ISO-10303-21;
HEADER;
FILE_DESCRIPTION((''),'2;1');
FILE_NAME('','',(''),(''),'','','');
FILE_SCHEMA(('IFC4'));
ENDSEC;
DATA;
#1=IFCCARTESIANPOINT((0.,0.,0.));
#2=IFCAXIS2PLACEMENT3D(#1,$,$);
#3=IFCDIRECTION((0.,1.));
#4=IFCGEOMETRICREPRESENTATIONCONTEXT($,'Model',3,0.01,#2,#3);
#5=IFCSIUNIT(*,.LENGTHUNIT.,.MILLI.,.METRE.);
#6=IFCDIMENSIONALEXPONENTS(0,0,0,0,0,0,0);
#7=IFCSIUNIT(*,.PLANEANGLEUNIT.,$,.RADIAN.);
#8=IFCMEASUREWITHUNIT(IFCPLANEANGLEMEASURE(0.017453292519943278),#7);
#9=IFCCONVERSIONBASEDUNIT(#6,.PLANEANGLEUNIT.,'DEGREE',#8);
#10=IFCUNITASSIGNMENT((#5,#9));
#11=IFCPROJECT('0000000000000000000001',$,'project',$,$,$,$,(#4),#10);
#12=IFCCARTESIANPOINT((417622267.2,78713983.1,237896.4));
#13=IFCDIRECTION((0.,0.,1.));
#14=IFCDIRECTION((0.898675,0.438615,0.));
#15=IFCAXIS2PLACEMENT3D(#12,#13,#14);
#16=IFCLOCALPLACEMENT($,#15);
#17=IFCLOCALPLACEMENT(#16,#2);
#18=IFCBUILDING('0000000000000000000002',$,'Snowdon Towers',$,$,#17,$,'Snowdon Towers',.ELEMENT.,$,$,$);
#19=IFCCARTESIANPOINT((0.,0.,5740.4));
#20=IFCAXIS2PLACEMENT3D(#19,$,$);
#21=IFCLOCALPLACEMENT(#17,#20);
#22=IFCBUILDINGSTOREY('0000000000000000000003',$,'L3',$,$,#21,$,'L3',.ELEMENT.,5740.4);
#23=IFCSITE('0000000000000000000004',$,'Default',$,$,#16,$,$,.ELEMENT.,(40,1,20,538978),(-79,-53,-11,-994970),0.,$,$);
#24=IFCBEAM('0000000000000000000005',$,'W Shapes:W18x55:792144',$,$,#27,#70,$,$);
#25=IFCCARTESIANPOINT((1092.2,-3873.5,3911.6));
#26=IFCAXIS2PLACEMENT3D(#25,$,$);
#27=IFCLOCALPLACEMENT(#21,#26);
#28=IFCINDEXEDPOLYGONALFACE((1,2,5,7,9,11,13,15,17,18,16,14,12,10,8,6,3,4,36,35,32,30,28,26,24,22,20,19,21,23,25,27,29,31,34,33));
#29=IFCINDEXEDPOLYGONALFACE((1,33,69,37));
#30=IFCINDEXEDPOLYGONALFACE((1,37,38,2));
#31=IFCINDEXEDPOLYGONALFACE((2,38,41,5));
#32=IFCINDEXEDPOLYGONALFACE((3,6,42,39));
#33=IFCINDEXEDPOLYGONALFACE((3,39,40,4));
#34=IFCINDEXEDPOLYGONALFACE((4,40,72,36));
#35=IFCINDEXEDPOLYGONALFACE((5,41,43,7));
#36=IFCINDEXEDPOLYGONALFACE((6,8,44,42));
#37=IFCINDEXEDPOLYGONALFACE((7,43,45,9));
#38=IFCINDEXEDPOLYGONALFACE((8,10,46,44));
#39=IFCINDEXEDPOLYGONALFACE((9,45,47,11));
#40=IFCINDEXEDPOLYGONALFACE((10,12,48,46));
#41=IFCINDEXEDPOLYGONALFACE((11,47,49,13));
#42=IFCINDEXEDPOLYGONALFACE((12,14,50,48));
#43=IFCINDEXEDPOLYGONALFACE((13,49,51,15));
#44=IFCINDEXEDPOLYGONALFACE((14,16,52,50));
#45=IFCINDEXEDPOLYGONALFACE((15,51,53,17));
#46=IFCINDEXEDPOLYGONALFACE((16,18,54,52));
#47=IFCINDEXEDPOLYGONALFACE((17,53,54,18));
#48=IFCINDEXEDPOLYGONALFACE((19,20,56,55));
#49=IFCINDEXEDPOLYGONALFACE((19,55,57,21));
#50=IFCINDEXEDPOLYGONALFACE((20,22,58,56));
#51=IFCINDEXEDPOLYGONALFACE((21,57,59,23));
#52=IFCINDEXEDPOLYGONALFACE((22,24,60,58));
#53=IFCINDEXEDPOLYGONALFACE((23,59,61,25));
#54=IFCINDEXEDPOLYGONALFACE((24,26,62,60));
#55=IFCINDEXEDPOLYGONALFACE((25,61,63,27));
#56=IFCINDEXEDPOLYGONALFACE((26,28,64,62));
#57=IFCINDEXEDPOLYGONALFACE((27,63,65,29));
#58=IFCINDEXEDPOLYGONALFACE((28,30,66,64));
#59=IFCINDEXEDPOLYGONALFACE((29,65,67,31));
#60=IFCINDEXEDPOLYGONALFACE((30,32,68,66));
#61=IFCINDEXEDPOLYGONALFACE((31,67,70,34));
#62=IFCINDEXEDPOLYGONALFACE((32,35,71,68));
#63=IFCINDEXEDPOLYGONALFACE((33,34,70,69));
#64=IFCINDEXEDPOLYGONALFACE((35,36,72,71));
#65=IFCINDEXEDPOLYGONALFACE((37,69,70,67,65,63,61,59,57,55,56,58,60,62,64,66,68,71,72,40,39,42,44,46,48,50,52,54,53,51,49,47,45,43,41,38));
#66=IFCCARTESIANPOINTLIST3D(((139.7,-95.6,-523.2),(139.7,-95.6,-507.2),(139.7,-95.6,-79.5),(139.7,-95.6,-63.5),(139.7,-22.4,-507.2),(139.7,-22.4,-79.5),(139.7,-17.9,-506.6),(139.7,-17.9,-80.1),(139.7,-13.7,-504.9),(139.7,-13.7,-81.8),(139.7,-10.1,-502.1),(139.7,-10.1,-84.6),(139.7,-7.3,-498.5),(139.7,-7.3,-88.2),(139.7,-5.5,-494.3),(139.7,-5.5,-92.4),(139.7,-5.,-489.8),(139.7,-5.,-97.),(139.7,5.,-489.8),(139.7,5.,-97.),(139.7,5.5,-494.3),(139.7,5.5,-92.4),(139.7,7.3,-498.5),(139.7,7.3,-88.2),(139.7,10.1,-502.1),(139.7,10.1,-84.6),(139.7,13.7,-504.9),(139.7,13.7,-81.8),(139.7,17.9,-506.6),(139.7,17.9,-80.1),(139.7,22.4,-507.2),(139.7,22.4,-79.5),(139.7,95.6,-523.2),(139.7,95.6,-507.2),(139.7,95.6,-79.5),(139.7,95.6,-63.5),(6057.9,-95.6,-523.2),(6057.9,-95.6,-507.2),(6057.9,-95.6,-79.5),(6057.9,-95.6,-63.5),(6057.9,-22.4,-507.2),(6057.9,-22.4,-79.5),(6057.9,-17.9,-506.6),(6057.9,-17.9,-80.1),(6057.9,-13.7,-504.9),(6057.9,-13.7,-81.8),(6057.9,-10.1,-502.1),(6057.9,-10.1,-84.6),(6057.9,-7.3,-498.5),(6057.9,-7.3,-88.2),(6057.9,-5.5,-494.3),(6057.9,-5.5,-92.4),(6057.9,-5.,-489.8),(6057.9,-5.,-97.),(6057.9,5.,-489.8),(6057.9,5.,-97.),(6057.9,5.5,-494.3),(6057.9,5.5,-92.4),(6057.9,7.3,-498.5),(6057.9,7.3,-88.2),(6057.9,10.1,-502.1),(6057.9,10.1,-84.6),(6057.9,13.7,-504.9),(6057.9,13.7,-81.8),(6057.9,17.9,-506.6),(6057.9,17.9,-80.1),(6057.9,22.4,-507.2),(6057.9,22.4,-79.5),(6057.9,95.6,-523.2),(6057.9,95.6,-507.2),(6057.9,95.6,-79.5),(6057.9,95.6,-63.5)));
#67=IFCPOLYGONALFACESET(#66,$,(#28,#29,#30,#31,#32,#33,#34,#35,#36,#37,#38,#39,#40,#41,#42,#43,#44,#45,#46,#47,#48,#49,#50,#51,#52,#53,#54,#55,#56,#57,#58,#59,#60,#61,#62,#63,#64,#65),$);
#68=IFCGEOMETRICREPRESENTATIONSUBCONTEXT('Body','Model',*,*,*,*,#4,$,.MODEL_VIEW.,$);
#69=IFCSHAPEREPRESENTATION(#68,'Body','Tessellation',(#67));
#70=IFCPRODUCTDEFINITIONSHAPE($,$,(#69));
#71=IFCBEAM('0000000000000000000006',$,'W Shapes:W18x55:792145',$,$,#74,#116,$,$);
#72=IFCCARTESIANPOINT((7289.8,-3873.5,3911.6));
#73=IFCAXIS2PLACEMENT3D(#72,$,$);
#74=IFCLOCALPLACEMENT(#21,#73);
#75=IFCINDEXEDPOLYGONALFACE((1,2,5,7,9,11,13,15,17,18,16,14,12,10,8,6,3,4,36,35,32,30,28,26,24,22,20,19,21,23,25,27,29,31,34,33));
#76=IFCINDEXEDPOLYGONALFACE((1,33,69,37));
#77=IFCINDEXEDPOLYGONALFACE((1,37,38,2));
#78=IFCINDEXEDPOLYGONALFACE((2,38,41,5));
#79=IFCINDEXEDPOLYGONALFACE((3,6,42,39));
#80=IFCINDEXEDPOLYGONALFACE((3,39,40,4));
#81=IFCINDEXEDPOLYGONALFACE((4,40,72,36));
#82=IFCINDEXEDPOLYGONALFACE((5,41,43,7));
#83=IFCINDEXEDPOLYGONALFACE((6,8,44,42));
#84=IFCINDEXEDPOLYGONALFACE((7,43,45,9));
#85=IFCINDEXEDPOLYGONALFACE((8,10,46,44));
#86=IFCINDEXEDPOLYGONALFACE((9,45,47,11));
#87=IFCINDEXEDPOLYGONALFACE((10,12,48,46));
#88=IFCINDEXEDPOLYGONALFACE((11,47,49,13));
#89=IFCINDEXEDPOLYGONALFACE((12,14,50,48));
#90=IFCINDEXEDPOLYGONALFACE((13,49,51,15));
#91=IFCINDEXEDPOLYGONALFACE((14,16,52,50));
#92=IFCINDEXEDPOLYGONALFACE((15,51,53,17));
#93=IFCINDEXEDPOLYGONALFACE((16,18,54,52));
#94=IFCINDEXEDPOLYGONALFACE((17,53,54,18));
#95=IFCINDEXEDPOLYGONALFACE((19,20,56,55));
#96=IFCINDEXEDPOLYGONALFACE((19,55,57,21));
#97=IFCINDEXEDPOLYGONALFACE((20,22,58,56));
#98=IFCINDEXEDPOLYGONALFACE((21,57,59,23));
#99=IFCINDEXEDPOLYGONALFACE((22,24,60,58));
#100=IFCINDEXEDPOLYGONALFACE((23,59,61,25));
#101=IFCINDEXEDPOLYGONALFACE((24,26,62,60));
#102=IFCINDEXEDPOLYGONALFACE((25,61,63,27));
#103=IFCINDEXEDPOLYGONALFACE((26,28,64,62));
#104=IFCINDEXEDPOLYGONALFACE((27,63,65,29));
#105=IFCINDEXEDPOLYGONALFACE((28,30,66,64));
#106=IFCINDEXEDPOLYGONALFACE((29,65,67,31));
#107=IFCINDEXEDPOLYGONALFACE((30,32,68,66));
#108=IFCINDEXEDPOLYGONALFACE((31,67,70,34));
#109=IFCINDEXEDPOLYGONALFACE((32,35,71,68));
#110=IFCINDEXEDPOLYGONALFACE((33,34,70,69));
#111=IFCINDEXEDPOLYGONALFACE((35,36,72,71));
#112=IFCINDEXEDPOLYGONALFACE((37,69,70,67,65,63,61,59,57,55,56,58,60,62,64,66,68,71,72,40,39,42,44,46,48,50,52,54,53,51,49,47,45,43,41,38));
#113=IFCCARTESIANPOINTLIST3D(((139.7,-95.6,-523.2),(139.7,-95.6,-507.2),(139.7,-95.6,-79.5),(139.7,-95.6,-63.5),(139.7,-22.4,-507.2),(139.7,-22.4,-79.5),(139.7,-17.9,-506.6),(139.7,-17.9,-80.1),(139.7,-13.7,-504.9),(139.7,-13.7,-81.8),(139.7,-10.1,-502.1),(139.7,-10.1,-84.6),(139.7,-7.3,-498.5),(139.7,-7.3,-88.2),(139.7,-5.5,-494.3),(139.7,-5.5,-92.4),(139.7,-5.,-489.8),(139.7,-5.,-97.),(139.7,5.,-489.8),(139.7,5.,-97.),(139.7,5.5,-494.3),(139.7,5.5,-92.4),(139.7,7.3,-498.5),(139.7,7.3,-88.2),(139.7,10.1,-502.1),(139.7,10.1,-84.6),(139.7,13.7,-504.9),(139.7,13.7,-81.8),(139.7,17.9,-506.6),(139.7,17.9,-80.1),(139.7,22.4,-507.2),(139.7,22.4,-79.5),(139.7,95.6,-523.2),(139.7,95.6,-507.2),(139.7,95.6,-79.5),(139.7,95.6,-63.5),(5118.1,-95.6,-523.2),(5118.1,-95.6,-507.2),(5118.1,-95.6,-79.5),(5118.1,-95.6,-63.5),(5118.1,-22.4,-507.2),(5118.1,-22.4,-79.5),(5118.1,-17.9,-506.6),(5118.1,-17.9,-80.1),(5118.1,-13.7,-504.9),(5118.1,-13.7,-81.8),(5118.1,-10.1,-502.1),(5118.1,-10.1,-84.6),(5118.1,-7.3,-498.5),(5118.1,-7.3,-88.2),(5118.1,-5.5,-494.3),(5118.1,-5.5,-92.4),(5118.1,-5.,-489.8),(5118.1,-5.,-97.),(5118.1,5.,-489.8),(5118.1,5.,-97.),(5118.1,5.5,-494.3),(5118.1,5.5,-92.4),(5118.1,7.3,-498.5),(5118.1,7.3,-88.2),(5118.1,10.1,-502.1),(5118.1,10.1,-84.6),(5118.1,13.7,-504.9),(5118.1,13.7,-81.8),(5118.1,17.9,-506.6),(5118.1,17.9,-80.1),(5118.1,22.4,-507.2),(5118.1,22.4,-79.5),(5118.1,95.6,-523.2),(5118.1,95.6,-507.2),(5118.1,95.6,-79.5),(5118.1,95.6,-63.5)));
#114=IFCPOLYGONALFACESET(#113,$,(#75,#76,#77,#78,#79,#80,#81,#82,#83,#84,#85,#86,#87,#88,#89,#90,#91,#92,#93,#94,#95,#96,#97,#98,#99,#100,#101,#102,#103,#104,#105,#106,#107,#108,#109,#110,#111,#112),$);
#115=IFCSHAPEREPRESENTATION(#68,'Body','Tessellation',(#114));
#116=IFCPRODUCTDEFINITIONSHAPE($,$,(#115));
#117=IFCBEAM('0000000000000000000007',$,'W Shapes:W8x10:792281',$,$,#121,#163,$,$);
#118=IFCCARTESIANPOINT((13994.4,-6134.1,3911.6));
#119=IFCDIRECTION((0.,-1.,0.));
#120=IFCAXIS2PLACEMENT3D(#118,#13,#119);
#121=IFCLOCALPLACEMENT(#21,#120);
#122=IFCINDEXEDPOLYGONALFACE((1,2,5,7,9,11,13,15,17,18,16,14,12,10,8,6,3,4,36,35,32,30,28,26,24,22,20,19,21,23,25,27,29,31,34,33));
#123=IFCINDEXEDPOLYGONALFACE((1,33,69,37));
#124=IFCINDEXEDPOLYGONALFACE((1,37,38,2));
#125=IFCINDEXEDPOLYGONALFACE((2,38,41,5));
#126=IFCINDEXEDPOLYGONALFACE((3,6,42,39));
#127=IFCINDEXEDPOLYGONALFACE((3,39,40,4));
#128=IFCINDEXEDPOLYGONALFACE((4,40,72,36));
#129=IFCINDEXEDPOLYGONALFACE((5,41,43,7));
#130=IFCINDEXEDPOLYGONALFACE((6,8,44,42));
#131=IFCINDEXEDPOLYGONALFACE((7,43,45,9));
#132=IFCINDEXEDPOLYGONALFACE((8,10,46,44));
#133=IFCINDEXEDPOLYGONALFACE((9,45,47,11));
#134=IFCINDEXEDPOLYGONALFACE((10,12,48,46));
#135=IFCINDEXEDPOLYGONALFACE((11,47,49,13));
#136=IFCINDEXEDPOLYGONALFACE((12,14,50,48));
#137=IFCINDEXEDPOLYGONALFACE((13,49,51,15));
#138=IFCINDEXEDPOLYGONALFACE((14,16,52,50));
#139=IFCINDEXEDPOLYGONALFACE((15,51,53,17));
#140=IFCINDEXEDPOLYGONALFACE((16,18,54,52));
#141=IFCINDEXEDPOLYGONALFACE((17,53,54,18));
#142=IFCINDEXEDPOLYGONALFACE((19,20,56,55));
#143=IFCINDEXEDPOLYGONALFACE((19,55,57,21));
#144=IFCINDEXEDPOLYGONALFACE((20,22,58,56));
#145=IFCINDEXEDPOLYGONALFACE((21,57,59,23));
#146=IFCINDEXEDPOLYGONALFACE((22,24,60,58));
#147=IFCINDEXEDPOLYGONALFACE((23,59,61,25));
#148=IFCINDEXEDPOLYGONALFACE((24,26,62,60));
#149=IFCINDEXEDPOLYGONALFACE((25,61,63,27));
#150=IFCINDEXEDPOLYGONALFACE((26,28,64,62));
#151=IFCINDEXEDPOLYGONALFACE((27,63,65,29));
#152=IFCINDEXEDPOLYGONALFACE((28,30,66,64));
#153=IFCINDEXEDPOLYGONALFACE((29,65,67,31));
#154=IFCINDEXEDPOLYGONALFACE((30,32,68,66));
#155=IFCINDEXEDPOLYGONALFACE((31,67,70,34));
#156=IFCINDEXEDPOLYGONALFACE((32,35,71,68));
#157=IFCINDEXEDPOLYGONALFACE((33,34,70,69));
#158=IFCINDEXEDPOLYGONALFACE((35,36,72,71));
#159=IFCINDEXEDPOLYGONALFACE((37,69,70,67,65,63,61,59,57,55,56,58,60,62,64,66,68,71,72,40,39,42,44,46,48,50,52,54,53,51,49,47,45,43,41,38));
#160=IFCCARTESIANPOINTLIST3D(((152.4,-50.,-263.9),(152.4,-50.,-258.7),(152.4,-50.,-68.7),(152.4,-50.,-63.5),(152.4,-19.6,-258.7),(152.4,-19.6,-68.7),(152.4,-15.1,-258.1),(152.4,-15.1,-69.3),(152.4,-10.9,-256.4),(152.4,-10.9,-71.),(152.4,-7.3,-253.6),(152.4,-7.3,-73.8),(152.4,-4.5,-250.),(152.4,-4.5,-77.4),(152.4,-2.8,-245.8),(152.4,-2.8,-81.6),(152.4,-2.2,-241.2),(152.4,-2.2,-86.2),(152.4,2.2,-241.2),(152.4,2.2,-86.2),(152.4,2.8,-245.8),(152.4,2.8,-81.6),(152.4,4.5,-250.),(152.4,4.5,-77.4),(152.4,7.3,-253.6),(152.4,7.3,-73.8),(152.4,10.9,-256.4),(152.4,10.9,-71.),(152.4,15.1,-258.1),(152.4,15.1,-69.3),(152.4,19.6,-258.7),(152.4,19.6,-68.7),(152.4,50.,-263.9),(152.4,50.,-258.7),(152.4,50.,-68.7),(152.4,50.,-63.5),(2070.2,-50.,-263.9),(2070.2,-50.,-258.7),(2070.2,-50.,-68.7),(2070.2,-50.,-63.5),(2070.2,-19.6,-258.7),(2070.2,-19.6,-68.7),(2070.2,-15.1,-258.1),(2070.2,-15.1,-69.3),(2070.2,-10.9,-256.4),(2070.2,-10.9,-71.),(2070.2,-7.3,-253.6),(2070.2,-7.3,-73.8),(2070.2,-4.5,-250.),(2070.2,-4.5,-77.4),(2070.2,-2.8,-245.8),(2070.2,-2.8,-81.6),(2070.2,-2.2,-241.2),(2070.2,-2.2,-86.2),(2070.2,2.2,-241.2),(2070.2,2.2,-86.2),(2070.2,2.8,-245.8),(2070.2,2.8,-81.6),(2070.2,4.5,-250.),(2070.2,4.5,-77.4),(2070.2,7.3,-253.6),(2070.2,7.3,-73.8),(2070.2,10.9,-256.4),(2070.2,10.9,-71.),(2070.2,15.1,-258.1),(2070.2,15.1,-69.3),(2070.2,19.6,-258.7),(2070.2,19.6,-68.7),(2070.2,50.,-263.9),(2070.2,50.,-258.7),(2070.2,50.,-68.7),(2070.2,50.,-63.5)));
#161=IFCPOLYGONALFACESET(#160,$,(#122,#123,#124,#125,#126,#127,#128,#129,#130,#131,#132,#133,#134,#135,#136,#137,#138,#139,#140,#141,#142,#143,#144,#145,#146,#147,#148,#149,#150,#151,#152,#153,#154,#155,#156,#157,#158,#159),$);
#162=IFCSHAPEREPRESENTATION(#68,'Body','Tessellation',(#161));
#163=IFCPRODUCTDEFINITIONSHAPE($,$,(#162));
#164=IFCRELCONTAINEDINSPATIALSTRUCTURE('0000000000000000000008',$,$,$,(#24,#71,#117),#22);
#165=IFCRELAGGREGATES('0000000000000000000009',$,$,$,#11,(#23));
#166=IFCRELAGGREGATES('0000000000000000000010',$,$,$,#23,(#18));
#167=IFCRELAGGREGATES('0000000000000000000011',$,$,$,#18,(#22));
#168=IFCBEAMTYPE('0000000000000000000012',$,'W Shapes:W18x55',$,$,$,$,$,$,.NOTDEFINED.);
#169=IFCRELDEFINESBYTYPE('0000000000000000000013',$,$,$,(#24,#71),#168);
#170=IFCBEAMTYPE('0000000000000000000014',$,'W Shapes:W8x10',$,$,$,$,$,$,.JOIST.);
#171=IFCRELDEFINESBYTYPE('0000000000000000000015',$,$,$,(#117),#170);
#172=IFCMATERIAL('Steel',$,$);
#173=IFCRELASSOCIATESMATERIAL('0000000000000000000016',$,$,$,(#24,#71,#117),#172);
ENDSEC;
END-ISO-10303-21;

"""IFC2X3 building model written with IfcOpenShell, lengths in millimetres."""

from ifc_helpers import new_model, entity, si_unit, converted_unit, direction, frame, frame_2d, origin, place, context, subcontext, project, spatial, i_section, extrude, material, type_object, element, save


model = new_model("IFC2X3")

# Units and contexts
model_context = context("Model", 3, precision=0.01, world=origin(), true_north=direction((0.0, 1.0)))
body_context = subcontext(model_context, "Body", "Model", "MODEL_VIEW")
ifc_project = project(units=[si_unit("LENGTHUNIT", "METRE", prefix="MILLI"), converted_unit("PLANEANGLEUNIT", "DEGREE", entity("IfcPlaneAngleMeasure", 0.017453292519943278), si_unit("PLANEANGLEUNIT", "RADIAN"), dimensions=[0, 0, 0, 0, 0, 0, 0])], contexts=[model_context])

# Site, building, storey
site_placement = place(None, frame((417622267.2, 78713983.1, 237896.4), z_axis=(0.0, 0.0, 1.0), x_axis=(0.898675, 0.438615, 0.0)))
site = spatial("IfcSite", under=ifc_project, at=site_placement, Name="Default", CompositionType="ELEMENT", RefLatitude=(40, 1, 20, 538978), RefLongitude=(-79, -53, -11, -994970), RefElevation=0.0)
building_placement = place(site_placement, origin())
building = spatial("IfcBuilding", under=site, at=building_placement, Name="Snowdon Towers", LongName="Snowdon Towers", CompositionType="ELEMENT")
storey_placement = place(building_placement, frame((0.0, 0.0, 5740.4)))
storey = spatial("IfcBuildingStorey", under=building, at=storey_placement, Name="L3", LongName="L3", CompositionType="ELEMENT", Elevation=5740.4)

# Shared definitions
ifc_material_1 = material(Name="Steel")

# Beams
beam_type_1 = type_object("IfcBeamType", Name="W Shapes:W18x55", PredefinedType="NOTDEFINED")
beam_1_placement = place(storey_placement, frame((1092.2, -3873.5, 3911.6)))
element("IfcBeam", 1, at=beam_1_placement, inside=storey, type_object=beam_type_1, material=ifc_material_1, Name="W Shapes:W18x55:792144", context=body_context, shape_type="SweptSolid", body=[
    extrude(i_section(OverallWidth=191.3, OverallDepth=459.7, WebThickness=9.9, FlangeThickness=16.0, FilletRadius=17.5, at=frame_2d((0.0, 0.0), x_axis=(0.0, 1.0))), frame((139.7, 0.0, -293.4), z_axis=(1.0, 0.0, 0.0), x_axis=(0.0, 0.0, -1.0)), (0.0, 0.0, 1.0), 5918.2),
])
beam_2_placement = place(storey_placement, frame((7289.8, -3873.5, 3911.6)))
element("IfcBeam", 2, at=beam_2_placement, inside=storey, type_object=beam_type_1, material=ifc_material_1, Name="W Shapes:W18x55:792145", context=body_context, shape_type="SweptSolid", body=[
    extrude(i_section(OverallWidth=191.3, OverallDepth=459.7, WebThickness=9.9, FlangeThickness=16.0, FilletRadius=17.5, at=frame_2d((0.0, 0.0), x_axis=(0.0, 1.0))), frame((139.7, 0.0, -293.4), z_axis=(1.0, 0.0, 0.0), x_axis=(0.0, 0.0, -1.0)), (0.0, 0.0, 1.0), 4978.4),
])
beam_type_2 = type_object("IfcBeamType", Name="W Shapes:W8x10", PredefinedType="JOIST")
beam_3_placement = place(storey_placement, frame((13994.4, -6134.1, 3911.6), z_axis=(0.0, 0.0, 1.0), x_axis=(0.0, -1.0, 0.0)))
element("IfcBeam", 3, at=beam_3_placement, inside=storey, type_object=beam_type_2, material=ifc_material_1, Name="W Shapes:W8x10:792281", context=body_context, shape_type="SweptSolid", body=[
    extrude(i_section(OverallWidth=100.1, OverallDepth=200.4, WebThickness=4.3, FlangeThickness=5.2, FilletRadius=17.5, at=frame_2d((0.0, 0.0), x_axis=(0.0, 1.0))), frame((152.4, 0.0, -163.7), z_axis=(1.0, 0.0, 0.0), x_axis=(0.0, 0.0, -1.0)), (0.0, 0.0, 1.0), 1917.8),
])

save(model, "model.ifc")
